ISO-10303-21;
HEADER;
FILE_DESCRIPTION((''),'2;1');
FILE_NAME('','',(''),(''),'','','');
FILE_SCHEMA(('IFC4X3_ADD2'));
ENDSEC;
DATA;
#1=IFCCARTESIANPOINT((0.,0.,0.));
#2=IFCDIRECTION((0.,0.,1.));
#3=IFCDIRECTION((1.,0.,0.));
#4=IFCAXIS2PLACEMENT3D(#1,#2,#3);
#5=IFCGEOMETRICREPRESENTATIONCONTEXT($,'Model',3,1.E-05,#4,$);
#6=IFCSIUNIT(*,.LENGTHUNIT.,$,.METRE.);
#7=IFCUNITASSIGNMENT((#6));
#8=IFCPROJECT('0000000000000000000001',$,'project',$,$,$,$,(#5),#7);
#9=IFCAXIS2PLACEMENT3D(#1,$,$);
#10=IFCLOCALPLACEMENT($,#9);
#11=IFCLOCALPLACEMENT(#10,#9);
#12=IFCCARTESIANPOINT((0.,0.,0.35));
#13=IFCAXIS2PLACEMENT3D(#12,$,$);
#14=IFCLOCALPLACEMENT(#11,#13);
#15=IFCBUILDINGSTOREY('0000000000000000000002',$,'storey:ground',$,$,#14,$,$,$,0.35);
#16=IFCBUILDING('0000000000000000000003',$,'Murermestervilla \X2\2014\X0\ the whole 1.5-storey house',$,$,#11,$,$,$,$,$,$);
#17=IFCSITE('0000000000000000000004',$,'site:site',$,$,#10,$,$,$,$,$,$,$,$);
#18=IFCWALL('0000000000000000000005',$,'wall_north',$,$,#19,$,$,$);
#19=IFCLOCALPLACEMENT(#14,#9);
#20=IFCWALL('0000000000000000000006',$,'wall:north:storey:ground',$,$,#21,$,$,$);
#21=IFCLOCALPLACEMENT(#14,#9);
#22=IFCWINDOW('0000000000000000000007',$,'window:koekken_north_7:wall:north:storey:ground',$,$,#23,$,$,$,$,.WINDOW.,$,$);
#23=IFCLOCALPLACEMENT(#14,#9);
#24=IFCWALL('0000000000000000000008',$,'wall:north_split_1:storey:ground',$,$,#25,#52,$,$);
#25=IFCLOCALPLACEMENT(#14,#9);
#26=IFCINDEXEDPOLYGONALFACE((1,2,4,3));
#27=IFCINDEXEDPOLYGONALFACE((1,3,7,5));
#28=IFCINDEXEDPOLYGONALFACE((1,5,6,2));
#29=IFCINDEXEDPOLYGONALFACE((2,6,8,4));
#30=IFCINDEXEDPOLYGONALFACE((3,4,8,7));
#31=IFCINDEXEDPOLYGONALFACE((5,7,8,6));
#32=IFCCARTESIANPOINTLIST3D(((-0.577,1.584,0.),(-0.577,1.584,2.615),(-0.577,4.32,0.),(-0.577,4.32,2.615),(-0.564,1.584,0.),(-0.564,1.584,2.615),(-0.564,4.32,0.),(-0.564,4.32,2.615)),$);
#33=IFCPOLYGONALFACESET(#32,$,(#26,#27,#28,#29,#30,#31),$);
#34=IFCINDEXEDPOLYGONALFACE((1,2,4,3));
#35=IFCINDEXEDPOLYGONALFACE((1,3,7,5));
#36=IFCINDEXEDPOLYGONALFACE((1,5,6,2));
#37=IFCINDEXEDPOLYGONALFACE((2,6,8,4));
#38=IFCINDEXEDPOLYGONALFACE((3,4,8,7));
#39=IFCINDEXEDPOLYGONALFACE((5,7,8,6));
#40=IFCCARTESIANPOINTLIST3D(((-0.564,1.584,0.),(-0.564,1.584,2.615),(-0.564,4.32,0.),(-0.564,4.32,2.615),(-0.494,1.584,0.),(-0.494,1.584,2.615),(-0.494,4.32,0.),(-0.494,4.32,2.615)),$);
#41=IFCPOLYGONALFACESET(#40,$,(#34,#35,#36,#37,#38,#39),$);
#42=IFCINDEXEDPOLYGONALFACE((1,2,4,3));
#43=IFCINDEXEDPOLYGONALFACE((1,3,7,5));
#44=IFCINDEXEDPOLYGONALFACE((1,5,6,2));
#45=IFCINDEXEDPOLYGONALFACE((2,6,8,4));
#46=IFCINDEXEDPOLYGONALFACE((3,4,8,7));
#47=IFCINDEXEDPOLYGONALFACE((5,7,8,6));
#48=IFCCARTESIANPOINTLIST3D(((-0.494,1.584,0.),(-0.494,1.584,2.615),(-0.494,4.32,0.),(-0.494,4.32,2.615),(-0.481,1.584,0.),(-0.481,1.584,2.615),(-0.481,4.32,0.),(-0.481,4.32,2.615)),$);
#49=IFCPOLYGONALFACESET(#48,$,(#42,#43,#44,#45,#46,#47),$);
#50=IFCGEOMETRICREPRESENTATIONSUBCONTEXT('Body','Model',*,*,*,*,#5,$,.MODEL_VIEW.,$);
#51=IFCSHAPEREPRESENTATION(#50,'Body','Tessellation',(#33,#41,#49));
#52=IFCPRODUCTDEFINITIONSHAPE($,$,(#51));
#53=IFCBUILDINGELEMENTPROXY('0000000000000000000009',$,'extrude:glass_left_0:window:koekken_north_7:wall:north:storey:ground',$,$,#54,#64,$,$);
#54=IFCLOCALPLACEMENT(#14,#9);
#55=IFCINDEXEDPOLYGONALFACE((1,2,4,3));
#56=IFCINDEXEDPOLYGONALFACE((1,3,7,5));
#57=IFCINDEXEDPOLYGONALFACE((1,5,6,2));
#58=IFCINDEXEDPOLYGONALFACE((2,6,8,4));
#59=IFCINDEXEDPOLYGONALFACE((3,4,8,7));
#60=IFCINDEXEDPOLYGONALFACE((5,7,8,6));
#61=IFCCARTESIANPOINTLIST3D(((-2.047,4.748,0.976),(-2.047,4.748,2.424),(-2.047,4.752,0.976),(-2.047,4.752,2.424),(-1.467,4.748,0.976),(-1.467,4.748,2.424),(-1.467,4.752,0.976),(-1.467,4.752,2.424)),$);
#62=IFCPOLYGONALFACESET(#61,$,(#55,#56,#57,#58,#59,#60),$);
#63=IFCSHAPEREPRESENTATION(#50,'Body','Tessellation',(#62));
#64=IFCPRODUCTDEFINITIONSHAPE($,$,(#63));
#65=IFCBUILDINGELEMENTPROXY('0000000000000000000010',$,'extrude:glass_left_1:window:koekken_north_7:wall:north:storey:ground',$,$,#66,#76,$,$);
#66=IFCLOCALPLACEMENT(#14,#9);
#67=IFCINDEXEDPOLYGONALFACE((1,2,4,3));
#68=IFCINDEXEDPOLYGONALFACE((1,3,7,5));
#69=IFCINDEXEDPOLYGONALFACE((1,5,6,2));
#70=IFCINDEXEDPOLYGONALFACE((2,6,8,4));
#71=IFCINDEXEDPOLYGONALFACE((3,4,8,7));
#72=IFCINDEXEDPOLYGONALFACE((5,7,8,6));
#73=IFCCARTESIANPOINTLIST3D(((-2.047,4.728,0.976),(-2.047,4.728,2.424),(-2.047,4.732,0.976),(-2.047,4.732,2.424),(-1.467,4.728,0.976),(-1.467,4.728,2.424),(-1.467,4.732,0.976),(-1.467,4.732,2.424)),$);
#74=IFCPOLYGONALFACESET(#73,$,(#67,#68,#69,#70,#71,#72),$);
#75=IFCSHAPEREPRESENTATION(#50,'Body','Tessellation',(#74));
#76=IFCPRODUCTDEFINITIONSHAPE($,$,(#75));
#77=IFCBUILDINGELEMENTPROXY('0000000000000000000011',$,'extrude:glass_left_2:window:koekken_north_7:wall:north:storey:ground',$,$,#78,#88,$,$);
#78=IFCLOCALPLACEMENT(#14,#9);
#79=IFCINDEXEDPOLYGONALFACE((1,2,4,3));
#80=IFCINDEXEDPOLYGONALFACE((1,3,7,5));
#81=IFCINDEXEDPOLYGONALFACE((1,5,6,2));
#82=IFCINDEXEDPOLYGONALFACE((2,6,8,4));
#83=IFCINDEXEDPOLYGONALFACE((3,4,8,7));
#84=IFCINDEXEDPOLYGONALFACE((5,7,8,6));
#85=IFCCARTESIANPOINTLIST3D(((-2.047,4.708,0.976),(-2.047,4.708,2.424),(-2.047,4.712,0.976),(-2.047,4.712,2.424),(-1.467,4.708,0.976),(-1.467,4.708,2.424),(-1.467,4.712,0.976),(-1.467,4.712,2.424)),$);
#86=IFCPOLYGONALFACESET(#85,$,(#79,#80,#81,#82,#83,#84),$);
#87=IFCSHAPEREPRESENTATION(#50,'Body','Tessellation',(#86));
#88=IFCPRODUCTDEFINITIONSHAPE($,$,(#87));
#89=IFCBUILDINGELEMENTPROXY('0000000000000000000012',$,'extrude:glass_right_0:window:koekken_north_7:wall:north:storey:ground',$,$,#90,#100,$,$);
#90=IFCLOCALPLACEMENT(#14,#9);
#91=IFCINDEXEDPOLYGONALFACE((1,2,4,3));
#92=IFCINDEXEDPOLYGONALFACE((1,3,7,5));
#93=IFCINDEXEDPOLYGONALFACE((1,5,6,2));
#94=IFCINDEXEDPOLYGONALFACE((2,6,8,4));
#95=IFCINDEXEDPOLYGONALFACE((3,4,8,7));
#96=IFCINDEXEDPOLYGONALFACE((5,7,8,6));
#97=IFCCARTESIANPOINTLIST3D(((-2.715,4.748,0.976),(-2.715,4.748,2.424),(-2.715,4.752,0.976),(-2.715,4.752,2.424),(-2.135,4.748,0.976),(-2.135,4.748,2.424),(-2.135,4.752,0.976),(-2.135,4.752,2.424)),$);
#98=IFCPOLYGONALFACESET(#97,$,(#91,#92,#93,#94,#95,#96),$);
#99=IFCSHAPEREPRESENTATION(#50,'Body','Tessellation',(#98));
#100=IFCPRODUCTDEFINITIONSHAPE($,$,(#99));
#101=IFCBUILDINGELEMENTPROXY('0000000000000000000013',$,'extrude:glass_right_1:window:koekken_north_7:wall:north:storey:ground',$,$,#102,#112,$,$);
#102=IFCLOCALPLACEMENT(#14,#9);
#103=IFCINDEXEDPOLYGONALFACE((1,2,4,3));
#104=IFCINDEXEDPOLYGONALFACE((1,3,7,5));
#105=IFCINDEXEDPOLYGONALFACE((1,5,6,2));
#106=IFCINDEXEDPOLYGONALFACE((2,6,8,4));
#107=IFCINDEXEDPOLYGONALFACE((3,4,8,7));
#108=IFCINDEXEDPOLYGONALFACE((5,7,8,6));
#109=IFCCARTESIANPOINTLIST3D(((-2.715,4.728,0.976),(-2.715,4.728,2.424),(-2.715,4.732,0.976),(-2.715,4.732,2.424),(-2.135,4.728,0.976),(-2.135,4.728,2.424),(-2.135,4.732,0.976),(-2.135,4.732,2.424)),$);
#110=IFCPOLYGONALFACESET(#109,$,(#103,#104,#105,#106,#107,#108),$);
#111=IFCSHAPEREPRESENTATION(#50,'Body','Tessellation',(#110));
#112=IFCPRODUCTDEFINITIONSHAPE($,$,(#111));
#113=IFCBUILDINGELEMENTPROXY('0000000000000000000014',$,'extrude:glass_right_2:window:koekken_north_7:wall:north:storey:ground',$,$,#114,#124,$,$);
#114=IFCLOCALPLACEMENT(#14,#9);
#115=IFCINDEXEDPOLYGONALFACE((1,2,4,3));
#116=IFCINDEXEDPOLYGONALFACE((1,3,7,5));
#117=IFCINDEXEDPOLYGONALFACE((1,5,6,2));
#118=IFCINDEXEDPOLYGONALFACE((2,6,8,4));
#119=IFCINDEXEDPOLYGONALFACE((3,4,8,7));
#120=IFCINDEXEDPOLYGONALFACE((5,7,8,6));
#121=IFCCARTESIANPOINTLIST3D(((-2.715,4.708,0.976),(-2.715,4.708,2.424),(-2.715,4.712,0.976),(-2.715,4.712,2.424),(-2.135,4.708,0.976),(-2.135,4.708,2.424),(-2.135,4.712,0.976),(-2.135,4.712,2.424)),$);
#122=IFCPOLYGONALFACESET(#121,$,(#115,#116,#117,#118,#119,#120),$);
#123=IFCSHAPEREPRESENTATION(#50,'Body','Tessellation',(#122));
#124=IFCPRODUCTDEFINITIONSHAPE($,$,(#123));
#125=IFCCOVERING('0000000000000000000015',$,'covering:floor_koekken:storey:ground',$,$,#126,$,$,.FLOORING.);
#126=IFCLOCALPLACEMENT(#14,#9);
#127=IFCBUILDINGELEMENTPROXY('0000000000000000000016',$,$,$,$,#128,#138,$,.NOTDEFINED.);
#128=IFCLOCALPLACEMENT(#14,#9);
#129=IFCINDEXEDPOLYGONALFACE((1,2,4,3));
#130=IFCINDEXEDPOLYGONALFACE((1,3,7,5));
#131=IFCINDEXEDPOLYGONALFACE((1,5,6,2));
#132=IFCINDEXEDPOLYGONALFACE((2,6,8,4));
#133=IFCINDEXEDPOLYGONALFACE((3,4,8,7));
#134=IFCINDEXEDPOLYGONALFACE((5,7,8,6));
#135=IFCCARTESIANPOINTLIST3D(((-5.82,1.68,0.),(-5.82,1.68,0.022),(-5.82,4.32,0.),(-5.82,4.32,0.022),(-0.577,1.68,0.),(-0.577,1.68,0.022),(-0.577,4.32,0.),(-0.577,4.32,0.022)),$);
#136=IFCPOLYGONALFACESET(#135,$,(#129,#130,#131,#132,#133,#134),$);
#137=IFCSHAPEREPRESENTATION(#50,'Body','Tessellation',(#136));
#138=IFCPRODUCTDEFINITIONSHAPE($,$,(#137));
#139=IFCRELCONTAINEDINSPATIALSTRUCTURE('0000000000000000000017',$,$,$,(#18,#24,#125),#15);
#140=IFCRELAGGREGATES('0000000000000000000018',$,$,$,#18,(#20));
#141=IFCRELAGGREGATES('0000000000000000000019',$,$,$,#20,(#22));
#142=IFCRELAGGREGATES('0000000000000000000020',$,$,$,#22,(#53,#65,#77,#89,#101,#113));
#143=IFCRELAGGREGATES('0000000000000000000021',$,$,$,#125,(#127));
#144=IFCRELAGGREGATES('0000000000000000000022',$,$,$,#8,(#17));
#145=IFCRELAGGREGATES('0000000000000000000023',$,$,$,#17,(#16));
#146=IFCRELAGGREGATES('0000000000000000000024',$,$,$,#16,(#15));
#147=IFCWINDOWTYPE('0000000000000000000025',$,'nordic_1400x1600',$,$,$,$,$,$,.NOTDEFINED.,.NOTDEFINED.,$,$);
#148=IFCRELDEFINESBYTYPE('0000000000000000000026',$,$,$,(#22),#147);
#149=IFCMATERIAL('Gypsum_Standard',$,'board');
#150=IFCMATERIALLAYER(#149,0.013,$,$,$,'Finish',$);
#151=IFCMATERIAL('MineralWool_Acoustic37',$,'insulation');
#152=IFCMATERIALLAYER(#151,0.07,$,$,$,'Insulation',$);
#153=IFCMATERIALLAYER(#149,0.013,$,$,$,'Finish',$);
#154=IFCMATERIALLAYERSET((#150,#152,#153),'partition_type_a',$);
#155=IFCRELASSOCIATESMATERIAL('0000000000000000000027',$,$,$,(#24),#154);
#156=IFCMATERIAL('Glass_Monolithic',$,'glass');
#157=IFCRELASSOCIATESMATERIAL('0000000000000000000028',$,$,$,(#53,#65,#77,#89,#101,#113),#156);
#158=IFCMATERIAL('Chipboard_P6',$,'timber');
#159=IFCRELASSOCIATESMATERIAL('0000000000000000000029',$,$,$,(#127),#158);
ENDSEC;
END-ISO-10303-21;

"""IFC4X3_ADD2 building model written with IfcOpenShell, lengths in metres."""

from ifc_helpers import new_model, si_unit, frame, origin, origin_with_axes, place, context, subcontext, project, spatial, polyline, rectangle, outline, extrude, source, transform, mapped, material, layer, layer_set, layer_usage, type_object, element, aggregate, save


model = new_model("IFC4X3_ADD2")

# Units and contexts
model_context = context("Model", 3, precision=1e-05, world=origin_with_axes())
body_context = subcontext(model_context, "Body", "Model", "MODEL_VIEW")
ifc_project = project(units=[si_unit("LENGTHUNIT", "METRE")], contexts=[model_context])

# Site, building, storey
site_placement = place(None, origin())
site = spatial("IfcSite", under=ifc_project, at=site_placement, Name="site:site")
building_placement = place(site_placement, origin())
building = spatial("IfcBuilding", under=site, at=building_placement, Name="Murermestervilla — the whole 1.5-storey house")
storey_placement = place(building_placement, frame((0.0, 0.0, 0.35)))
storey = spatial("IfcBuildingStorey", under=building, at=storey_placement, Name="storey:ground", Elevation=0.35)

# Walls, window
wall_1_placement = place(storey_placement, origin())
wall_1 = element("IfcWall", 1, at=wall_1_placement, inside=storey, Name="wall_north")
wall_2_placement = place(wall_1_placement, frame((0.0, 0.0, -0.35)))
wall_2 = element("IfcWall", 2, at=wall_2_placement, Name="wall:north:storey:ground")
aggregate(wall_1, [wall_2])
window_type = type_object("IfcWindowType", Name="nordic_1400x1600", PartitioningType="NOTDEFINED", PredefinedType="NOTDEFINED")
window_placement = place(None, frame((-2.091, 4.828, 1.25), z_axis=(0.0, 0.0, 1.0), x_axis=(-1.0, 0.0, 0.0)))
window = element("IfcWindow", 3, at=window_placement, type_object=window_type, Name="window:koekken_north_7:wall:north:storey:ground", PredefinedType="WINDOW")
aggregate(wall_2, [window])

# Shared definitions
ifc_material_1 = material(Name="Gypsum_Standard", Category="board")
ifc_layer_1 = layer(ifc_material_1, 0.013, Category="Finish")
ifc_material_2 = material(Name="MineralWool_Acoustic37", Category="insulation")
ifc_layer_2 = layer(ifc_material_2, 0.07, Category="Insulation")
ifc_layer_3 = layer(ifc_material_1, 0.013, Category="Finish")
ifc_layer_set = layer_set([ifc_layer_1, ifc_layer_2, ifc_layer_3], Name="partition_type_a")

# Wall
ifc_layer_usage_1 = layer_usage(ifc_layer_set, "AXIS1", "NEGATIVE", 0.048)
wall_3_placement = place(storey_placement, frame((-0.529, 2.952, 1.3075)))
element("IfcWall", 4, at=wall_3_placement, inside=storey, material=ifc_layer_usage_1, Name="wall:north_split_1:storey:ground", context=body_context, shape_type="SweptSolid", body=[
    extrude(rectangle(XDim=0.013, YDim=2.736), frame((-0.0415, 0.0, -1.3075)), (0.0, 0.0, 1.0), 2.615),
    extrude(rectangle(XDim=0.07, YDim=2.736), frame((0.0, 0.0, -1.3075)), (0.0, 0.0, 1.0), 2.615),
    extrude(rectangle(XDim=0.013, YDim=2.736), frame((0.0415, 0.0, -1.3075)), (0.0, 0.0, 1.0), 2.615),
])

# Building element proxies
ifc_material_3 = material(Name="Glass_Monolithic", Category="glass")
shared_shape_1 = source(origin(), body_context, "Body", "SweptSolid", [
    extrude(outline(polyline([(-0.29, -0.724), (0.29, -0.724), (0.29, 0.724), (-0.29, 0.724), (-0.29, -0.724)])), frame((0.0, 0.0, -0.002)), (0.0, 0.0, 1.0), 0.004),
])
proxy_1_placement = place(None, frame((-1.757, 4.75, 2.05), z_axis=(0.0, 1.0, 0.0), x_axis=(-1.0, 0.0, 0.0)))
proxy_1 = element("IfcBuildingElementProxy", 5, at=proxy_1_placement, material=ifc_material_3, Name="extrude:glass_left_0:window:koekken_north_7:wall:north:storey:ground", context=body_context, shape_type="MappedRepresentation", body=[
    mapped(shared_shape_1, transform((0.0, 0.0, 0.0))),
])
shared_shape_2 = source(origin(), body_context, "Body", "SweptSolid", [
    extrude(outline(polyline([(-0.29, -0.724), (0.29, -0.724), (0.29, 0.724), (-0.29, 0.724), (-0.29, -0.724)])), frame((0.0, 0.0, -0.002)), (0.0, 0.0, 1.0), 0.004),
])
proxy_2_placement = place(None, frame((-1.757, 4.73, 2.05), z_axis=(0.0, 1.0, 0.0), x_axis=(-1.0, 0.0, 0.0)))
proxy_2 = element("IfcBuildingElementProxy", 6, at=proxy_2_placement, material=ifc_material_3, Name="extrude:glass_left_1:window:koekken_north_7:wall:north:storey:ground", context=body_context, shape_type="MappedRepresentation", body=[
    mapped(shared_shape_2, transform((0.0, 0.0, 0.0))),
])
shared_shape_3 = source(origin(), body_context, "Body", "SweptSolid", [
    extrude(outline(polyline([(-0.29, -0.724), (0.29, -0.724), (0.29, 0.724), (-0.29, 0.724), (-0.29, -0.724)])), frame((0.0, 0.0, -0.002)), (0.0, 0.0, 1.0), 0.004),
])
proxy_3_placement = place(None, frame((-1.757, 4.71, 2.05), z_axis=(0.0, 1.0, 0.0), x_axis=(-1.0, 0.0, 0.0)))
proxy_3 = element("IfcBuildingElementProxy", 7, at=proxy_3_placement, material=ifc_material_3, Name="extrude:glass_left_2:window:koekken_north_7:wall:north:storey:ground", context=body_context, shape_type="MappedRepresentation", body=[
    mapped(shared_shape_3, transform((0.0, 0.0, 0.0))),
])
shared_shape_4 = source(origin(), body_context, "Body", "SweptSolid", [
    extrude(outline(polyline([(-0.29, -0.724), (0.29, -0.724), (0.29, 0.724), (-0.29, 0.724), (-0.29, -0.724)])), frame((0.0, 0.0, -0.002)), (0.0, 0.0, 1.0), 0.004),
])
proxy_4_placement = place(None, frame((-2.425, 4.75, 2.05), z_axis=(0.0, 1.0, 0.0), x_axis=(-1.0, 0.0, 0.0)))
proxy_4 = element("IfcBuildingElementProxy", 8, at=proxy_4_placement, material=ifc_material_3, Name="extrude:glass_right_0:window:koekken_north_7:wall:north:storey:ground", context=body_context, shape_type="MappedRepresentation", body=[
    mapped(shared_shape_4, transform((0.0, 0.0, 0.0))),
])
shared_shape_5 = source(origin(), body_context, "Body", "SweptSolid", [
    extrude(outline(polyline([(-0.29, -0.724), (0.29, -0.724), (0.29, 0.724), (-0.29, 0.724), (-0.29, -0.724)])), frame((0.0, 0.0, -0.002)), (0.0, 0.0, 1.0), 0.004),
])
proxy_5_placement = place(None, frame((-2.425, 4.73, 2.05), z_axis=(0.0, 1.0, 0.0), x_axis=(-1.0, 0.0, 0.0)))
proxy_5 = element("IfcBuildingElementProxy", 9, at=proxy_5_placement, material=ifc_material_3, Name="extrude:glass_right_1:window:koekken_north_7:wall:north:storey:ground", context=body_context, shape_type="MappedRepresentation", body=[
    mapped(shared_shape_5, transform((0.0, 0.0, 0.0))),
])
shared_shape_6 = source(origin(), body_context, "Body", "SweptSolid", [
    extrude(outline(polyline([(-0.29, -0.724), (0.29, -0.724), (0.29, 0.724), (-0.29, 0.724), (-0.29, -0.724)])), frame((0.0, 0.0, -0.002)), (0.0, 0.0, 1.0), 0.004),
])
proxy_6_placement = place(None, frame((-2.425, 4.71, 2.05), z_axis=(0.0, 1.0, 0.0), x_axis=(-1.0, 0.0, 0.0)))
proxy_6 = element("IfcBuildingElementProxy", 10, at=proxy_6_placement, material=ifc_material_3, Name="extrude:glass_right_2:window:koekken_north_7:wall:north:storey:ground", context=body_context, shape_type="MappedRepresentation", body=[
    mapped(shared_shape_6, transform((0.0, 0.0, 0.0))),
])
aggregate(window, [proxy_1, proxy_2, proxy_3, proxy_4, proxy_5, proxy_6])

# Covering, building element proxy
covering_placement = place(storey_placement, frame((0.0, 0.0, -0.35)))
covering = element("IfcCovering", 11, at=covering_placement, inside=storey, Name="covering:floor_koekken:storey:ground", PredefinedType="FLOORING")
ifc_material_4 = material(Name="Chipboard_P6", Category="timber")
proxy_7_placement = place(None, frame((-3.1985, 3.0, 0.361)))
proxy_7 = element("IfcBuildingElementProxy", 12, at=proxy_7_placement, material=ifc_material_4, PredefinedType="NOTDEFINED", context=body_context, shape_type="SweptSolid", body=[
    extrude(rectangle(XDim=5.243, YDim=2.64), frame((0.0, 0.0, -0.011)), (0.0, 0.0, 1.0), 0.022),
])
aggregate(covering, [proxy_7])

save(model, "model.ifc")
